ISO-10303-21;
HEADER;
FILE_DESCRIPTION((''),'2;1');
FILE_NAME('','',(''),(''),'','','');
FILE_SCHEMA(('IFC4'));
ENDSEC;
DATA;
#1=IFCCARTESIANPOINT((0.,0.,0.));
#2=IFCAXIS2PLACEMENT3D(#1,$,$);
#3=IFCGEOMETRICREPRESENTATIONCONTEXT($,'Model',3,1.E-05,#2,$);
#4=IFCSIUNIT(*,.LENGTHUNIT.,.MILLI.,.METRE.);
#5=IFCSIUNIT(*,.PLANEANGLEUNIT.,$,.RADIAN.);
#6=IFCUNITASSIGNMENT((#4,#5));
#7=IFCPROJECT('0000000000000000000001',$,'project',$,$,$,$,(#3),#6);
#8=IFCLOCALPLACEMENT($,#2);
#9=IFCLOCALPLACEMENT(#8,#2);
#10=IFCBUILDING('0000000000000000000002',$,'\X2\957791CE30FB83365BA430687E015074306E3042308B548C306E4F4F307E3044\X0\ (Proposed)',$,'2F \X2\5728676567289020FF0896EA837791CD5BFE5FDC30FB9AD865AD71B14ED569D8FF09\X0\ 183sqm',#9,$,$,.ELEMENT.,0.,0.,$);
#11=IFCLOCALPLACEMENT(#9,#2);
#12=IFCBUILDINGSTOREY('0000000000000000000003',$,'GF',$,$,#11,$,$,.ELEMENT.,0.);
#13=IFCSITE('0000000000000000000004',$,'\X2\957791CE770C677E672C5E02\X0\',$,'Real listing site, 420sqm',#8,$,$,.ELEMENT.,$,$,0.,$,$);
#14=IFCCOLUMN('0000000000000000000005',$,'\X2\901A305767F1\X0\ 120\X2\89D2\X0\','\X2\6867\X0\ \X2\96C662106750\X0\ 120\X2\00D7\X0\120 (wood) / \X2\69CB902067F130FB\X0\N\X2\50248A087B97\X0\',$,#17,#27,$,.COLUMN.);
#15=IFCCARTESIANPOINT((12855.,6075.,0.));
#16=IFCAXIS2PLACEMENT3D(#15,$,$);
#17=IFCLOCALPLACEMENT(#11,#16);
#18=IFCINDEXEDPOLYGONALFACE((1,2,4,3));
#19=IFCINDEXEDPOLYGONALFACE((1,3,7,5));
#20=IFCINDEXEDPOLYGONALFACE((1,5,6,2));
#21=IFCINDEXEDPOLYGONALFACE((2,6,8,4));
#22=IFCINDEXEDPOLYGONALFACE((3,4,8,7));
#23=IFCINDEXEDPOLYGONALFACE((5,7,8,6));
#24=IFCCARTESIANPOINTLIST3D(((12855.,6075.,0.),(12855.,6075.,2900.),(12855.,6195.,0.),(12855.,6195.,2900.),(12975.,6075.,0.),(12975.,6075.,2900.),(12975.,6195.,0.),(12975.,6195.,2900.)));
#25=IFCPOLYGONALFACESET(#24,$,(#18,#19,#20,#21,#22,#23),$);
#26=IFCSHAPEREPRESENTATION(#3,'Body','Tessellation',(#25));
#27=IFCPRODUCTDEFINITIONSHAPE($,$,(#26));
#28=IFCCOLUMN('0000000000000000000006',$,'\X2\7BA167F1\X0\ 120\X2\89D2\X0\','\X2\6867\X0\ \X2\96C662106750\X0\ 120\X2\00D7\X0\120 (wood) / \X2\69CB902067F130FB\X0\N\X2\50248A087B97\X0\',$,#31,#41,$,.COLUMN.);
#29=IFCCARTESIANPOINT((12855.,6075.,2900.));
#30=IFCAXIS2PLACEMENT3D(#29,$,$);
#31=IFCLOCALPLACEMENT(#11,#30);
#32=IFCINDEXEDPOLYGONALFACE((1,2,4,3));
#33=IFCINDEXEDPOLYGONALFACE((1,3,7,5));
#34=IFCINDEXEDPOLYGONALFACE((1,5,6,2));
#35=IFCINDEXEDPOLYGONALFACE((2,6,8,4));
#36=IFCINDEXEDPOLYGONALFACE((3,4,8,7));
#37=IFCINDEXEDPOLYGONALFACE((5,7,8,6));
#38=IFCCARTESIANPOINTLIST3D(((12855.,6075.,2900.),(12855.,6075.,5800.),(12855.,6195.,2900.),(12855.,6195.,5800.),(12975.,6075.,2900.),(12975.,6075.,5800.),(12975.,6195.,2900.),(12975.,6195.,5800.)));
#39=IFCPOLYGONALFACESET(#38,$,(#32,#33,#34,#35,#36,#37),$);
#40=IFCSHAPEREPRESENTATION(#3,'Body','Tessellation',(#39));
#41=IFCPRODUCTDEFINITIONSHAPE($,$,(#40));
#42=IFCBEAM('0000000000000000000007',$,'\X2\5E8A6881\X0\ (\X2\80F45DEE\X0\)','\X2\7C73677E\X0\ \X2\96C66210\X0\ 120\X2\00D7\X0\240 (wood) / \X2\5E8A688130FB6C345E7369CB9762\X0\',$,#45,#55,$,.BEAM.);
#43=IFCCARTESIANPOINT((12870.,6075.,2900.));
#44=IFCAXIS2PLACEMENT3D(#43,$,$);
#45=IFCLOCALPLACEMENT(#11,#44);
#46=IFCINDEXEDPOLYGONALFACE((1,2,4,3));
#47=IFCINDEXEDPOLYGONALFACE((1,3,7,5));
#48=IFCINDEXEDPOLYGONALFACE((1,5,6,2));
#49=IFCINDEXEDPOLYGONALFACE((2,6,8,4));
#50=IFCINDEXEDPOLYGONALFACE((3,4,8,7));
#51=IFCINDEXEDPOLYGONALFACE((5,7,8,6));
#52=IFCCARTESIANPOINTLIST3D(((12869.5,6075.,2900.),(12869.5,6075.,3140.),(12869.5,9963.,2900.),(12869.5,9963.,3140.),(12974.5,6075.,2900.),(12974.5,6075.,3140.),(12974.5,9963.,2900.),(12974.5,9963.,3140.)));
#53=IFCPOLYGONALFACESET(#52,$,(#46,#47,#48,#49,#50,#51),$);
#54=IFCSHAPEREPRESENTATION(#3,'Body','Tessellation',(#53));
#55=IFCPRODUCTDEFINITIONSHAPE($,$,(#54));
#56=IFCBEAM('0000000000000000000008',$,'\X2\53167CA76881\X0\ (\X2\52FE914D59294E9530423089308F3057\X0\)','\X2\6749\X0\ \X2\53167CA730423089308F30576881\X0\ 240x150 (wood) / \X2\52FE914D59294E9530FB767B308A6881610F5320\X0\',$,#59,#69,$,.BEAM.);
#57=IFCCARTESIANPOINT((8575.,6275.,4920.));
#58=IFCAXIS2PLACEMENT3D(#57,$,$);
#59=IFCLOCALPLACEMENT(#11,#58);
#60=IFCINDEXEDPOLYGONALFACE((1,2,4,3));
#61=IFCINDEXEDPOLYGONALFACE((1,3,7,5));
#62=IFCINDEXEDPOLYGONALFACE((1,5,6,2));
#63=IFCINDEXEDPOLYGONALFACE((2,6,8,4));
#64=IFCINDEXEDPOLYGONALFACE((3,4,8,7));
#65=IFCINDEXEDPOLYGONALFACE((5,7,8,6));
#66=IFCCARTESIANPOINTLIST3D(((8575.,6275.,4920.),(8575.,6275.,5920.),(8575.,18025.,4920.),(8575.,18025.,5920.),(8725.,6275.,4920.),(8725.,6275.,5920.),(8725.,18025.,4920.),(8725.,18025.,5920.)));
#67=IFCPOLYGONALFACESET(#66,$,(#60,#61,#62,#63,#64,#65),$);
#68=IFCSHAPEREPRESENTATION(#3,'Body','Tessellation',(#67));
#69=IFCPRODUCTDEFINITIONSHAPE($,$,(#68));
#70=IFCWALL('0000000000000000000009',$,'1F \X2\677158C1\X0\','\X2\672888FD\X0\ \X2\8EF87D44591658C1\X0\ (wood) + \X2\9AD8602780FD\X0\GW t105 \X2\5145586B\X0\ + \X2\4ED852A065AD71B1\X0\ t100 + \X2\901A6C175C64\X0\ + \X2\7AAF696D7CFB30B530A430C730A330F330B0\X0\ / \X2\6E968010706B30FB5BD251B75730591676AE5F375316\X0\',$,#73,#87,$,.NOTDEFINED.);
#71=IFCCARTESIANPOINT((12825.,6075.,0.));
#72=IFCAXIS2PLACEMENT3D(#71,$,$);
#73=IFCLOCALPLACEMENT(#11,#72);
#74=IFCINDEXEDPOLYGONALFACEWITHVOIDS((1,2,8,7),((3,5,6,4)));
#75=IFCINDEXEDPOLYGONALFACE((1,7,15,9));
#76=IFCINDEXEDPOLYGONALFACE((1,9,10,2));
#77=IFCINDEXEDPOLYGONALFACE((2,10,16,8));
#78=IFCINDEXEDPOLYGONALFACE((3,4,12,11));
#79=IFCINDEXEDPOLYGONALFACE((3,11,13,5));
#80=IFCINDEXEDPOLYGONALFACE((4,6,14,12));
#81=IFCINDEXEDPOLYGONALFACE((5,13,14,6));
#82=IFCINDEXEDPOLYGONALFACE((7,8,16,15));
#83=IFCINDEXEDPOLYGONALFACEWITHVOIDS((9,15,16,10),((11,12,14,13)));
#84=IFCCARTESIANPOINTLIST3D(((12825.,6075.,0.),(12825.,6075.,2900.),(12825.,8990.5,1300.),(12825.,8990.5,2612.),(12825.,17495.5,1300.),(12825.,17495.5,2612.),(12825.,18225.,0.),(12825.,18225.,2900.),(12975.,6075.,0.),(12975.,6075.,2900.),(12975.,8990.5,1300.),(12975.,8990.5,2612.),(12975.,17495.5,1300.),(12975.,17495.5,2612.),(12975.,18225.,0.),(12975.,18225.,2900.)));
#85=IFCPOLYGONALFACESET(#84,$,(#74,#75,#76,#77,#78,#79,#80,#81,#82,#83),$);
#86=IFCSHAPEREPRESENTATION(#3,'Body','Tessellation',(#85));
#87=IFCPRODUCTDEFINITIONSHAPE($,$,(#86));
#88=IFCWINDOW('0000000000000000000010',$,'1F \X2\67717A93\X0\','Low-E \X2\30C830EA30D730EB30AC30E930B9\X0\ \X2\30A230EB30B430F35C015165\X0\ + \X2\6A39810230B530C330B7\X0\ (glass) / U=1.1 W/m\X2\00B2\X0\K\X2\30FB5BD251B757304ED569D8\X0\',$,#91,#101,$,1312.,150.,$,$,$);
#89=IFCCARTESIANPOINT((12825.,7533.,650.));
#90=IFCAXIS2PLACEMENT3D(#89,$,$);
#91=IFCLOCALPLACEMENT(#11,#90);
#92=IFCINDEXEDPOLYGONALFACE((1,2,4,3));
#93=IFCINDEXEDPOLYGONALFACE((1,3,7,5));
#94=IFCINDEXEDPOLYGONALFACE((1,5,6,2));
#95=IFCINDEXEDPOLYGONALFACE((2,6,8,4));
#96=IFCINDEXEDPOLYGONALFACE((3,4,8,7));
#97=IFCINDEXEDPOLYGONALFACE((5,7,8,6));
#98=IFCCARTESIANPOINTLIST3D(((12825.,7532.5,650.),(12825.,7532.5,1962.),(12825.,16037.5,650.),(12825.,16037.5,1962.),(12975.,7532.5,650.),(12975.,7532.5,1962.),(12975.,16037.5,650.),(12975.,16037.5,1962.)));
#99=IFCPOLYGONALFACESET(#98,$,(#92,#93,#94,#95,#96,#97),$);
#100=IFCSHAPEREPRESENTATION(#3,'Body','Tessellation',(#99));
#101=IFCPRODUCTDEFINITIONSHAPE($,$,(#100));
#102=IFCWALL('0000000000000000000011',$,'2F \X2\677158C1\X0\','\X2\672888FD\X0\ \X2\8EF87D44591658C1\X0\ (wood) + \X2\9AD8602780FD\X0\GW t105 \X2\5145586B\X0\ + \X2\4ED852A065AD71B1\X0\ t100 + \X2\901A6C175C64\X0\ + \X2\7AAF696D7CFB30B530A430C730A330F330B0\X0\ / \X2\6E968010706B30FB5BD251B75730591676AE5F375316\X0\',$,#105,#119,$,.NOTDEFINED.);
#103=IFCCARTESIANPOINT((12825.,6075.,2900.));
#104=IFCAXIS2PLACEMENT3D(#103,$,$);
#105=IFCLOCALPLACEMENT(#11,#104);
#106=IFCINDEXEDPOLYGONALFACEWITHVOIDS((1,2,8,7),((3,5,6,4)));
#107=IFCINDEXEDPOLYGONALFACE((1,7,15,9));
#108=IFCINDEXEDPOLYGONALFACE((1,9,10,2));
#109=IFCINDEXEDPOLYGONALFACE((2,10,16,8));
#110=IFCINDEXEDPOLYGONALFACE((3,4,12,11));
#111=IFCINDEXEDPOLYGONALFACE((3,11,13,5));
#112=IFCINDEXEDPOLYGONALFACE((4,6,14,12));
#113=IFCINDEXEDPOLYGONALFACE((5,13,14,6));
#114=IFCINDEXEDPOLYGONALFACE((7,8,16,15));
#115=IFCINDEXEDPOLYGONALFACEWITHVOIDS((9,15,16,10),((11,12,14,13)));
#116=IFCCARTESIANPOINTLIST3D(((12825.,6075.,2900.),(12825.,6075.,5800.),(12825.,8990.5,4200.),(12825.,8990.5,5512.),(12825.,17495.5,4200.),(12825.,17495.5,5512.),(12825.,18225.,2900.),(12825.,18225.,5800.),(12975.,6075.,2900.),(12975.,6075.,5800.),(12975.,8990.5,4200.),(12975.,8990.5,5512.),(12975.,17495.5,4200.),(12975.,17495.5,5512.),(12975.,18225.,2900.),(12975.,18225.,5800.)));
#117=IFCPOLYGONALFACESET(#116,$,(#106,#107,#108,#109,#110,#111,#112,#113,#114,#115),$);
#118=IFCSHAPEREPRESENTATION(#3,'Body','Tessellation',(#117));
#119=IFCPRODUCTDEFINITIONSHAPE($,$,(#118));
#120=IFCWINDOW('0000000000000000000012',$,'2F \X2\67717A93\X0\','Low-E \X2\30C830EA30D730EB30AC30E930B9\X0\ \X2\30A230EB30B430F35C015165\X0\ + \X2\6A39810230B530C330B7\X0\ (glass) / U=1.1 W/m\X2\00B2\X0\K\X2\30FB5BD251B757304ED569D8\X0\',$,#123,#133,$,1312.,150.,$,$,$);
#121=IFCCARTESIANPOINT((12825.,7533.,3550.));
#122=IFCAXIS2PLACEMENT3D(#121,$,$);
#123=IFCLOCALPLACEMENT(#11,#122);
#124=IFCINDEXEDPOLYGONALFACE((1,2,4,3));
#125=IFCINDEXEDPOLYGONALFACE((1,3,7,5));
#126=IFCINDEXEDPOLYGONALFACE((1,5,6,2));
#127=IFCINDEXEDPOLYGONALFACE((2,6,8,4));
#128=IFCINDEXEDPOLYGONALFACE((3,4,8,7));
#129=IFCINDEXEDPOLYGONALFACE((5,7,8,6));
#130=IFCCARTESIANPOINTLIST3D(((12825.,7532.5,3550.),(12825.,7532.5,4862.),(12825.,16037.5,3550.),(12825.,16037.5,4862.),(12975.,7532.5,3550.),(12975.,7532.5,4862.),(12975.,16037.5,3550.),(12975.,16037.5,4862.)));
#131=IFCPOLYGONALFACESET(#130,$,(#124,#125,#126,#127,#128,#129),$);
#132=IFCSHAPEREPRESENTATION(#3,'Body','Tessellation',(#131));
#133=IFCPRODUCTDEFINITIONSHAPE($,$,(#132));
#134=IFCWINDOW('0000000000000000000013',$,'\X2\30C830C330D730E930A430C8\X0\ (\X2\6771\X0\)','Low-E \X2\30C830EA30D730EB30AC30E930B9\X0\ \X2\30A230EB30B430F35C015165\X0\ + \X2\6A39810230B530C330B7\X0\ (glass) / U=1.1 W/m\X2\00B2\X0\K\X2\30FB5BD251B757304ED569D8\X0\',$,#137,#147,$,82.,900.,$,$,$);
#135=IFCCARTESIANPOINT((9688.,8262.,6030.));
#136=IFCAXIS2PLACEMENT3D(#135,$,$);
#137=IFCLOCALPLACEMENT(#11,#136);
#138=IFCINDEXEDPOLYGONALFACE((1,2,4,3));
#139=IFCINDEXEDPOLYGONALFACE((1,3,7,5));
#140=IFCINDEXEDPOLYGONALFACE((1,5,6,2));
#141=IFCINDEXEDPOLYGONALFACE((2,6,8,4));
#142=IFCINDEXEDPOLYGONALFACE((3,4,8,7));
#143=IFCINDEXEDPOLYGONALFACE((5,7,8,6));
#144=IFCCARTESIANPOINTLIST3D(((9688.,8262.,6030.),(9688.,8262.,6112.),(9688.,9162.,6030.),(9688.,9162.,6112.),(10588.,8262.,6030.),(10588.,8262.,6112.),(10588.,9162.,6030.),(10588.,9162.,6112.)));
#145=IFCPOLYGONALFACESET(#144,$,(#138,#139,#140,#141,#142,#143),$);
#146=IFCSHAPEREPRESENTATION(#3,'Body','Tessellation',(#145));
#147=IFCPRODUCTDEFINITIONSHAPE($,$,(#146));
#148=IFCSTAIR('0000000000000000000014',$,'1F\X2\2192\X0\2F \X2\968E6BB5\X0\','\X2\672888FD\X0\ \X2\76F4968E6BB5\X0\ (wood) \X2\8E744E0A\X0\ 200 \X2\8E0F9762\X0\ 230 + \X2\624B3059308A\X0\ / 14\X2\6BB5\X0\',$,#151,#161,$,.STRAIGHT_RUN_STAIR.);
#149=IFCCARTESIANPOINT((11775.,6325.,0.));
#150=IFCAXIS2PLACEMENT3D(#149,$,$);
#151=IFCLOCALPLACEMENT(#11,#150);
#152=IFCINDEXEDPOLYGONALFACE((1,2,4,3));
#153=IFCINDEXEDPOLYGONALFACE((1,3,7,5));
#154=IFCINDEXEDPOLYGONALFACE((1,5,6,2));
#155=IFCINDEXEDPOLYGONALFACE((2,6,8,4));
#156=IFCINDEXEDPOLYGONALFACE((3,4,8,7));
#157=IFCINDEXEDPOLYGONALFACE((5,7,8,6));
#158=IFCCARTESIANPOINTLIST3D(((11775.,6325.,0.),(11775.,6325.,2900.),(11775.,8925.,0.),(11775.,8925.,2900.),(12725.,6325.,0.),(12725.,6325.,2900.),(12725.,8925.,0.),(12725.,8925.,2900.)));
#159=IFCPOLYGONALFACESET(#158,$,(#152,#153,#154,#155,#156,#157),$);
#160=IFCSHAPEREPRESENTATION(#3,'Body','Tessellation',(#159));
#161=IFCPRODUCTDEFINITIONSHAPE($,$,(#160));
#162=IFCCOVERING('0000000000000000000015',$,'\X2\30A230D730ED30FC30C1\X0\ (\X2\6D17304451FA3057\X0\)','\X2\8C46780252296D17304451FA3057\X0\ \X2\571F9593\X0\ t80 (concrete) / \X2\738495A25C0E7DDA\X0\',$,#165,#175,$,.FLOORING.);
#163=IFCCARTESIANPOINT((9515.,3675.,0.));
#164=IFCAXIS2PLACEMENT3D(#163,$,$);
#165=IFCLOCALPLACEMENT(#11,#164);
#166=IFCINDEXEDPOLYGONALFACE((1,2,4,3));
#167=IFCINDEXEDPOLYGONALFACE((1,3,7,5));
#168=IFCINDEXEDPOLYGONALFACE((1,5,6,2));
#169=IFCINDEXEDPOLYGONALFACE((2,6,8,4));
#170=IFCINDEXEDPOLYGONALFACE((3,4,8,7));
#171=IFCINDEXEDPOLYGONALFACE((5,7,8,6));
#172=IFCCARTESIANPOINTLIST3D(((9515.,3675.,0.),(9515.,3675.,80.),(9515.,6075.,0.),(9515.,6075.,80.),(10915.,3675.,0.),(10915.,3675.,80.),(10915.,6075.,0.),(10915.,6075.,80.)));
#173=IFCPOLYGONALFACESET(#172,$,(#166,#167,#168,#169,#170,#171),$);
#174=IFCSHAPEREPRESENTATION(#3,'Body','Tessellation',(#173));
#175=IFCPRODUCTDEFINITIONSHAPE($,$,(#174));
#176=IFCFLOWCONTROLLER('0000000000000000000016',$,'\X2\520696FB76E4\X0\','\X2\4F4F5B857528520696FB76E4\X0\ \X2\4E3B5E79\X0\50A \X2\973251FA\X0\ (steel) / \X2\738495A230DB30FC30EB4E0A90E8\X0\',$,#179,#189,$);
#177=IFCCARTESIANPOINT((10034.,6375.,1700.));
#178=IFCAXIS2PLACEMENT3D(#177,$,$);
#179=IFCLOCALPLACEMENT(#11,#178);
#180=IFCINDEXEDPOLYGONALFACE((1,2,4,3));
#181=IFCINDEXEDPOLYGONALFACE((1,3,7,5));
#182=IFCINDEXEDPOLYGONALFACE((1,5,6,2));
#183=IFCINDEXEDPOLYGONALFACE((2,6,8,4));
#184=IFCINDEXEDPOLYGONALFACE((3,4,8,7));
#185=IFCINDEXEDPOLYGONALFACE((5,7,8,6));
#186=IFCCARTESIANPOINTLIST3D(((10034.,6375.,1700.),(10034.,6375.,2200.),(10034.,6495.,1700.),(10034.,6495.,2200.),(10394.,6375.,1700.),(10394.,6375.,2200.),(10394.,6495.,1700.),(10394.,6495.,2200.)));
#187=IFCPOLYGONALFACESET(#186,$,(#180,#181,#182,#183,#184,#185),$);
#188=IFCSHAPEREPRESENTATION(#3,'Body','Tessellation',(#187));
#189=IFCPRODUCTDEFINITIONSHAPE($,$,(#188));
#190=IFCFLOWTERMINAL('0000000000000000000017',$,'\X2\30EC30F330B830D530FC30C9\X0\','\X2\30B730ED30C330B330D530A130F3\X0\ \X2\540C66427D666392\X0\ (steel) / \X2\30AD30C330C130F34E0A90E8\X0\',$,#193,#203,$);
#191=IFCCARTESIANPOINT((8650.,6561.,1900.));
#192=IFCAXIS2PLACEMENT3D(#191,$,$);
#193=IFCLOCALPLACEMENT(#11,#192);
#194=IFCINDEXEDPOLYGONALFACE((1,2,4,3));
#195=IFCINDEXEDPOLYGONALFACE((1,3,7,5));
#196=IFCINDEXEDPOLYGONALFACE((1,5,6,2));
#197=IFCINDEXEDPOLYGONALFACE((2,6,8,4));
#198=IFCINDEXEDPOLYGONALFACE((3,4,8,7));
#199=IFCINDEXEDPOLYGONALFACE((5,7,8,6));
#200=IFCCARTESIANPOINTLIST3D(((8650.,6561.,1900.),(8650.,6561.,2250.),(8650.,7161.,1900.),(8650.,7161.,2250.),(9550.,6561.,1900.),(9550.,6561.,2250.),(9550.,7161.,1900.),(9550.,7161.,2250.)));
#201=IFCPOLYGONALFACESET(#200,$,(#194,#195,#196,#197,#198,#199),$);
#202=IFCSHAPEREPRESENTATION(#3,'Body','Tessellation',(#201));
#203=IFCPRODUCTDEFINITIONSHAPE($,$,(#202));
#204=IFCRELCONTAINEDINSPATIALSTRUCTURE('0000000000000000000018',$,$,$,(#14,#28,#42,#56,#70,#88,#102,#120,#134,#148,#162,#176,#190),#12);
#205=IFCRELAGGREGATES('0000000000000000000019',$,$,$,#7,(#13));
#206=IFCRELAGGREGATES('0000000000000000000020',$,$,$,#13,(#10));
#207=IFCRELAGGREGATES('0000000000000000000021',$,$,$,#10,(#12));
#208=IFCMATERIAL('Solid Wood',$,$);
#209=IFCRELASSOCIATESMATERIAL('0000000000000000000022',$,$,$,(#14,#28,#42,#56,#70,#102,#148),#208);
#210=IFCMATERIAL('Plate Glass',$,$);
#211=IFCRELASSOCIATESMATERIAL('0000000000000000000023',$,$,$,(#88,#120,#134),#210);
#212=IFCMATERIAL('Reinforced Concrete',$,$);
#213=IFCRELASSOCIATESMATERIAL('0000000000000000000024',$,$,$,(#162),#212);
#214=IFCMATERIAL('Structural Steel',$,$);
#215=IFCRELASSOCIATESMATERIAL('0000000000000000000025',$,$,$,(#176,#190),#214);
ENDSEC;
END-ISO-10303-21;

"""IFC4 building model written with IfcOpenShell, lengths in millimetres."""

from ifc_helpers import new_model, si_unit, frame, frame_2d, origin, place, context, project, spatial, rectangle, extrude, material, element, fill, save


model = new_model("IFC4")

# Units and contexts
model_context = context("Model", 3, precision=1e-05, world=origin())
ifc_project = project(units=[si_unit("LENGTHUNIT", "METRE", prefix="MILLI"), si_unit("PLANEANGLEUNIT", "RADIAN")], contexts=[model_context])

# Site, building, storey
site_placement = place(None, origin())
site = spatial("IfcSite", under=ifc_project, at=site_placement, Name="長野県松本市", ObjectType="Real listing site, 420sqm", CompositionType="ELEMENT", RefElevation=0.0)
building_placement = place(site_placement, origin())
building = spatial("IfcBuilding", under=site, at=building_placement, Name="長野・茶室と縁側のある和の住まい (Proposed)", ObjectType="2F 在来木造（雪荷重対応・高断熱仕様） 183sqm", CompositionType="ELEMENT", ElevationOfRefHeight=0.0, ElevationOfTerrain=0.0)
storey_placement = place(building_placement, origin())
storey = spatial("IfcBuildingStorey", under=building, at=storey_placement, Name="GF", CompositionType="ELEMENT", Elevation=0.0)

# Columns
ifc_material_1 = material(Name="Solid Wood")
column_1_placement = place(storey_placement, frame((12855.0, 6075.0, 0.0)))
element("IfcColumn", 1, at=column_1_placement, inside=storey, material=ifc_material_1, Name="通し柱 120角", Description="桧 集成材 120×120 (wood) / 構造柱・N値計算", PredefinedType="COLUMN", context=model_context, shape_type="SweptSolid", body=[
    extrude(rectangle(XDim=120.0, YDim=120.0, at=frame_2d((60.0, 60.0))), frame((12855.0, 6075.0, 0.0)), (0.0, 0.0, 1.0), 2900.0),
])
column_2_placement = place(storey_placement, frame((12855.0, 6075.0, 2900.0)))
element("IfcColumn", 2, at=column_2_placement, inside=storey, material=ifc_material_1, Name="管柱 120角", Description="桧 集成材 120×120 (wood) / 構造柱・N値計算", PredefinedType="COLUMN", context=model_context, shape_type="SweptSolid", body=[
    extrude(rectangle(XDim=120.0, YDim=120.0, at=frame_2d((60.0, 60.0))), frame((12855.0, 6075.0, 2900.0)), (0.0, 0.0, 1.0), 2900.0),
])

# Beams
beam_1_placement = place(storey_placement, frame((12870.0, 6075.0, 2900.0)))
element("IfcBeam", 3, at=beam_1_placement, inside=storey, material=ifc_material_1, Name="床梁 (胴差)", Description="米松 集成 120×240 (wood) / 床梁・水平構面", PredefinedType="BEAM", context=model_context, shape_type="SweptSolid", body=[
    extrude(rectangle(XDim=105.0, YDim=3888.0, at=frame_2d((52.0, 1944.0))), frame((12870.0, 6075.0, 2900.0)), (0.0, 0.0, 1.0), 240.0),
])
beam_2_placement = place(storey_placement, frame((8575.0, 6275.0, 4920.0)))
element("IfcBeam", 4, at=beam_2_placement, inside=storey, material=ifc_material_1, Name="化粧梁 (勾配天井あらわし)", Description="杉 化粧あらわし梁 240x150 (wood) / 勾配天井・登り梁意匠", PredefinedType="BEAM", context=model_context, shape_type="SweptSolid", body=[
    extrude(rectangle(XDim=150.0, YDim=11750.0, at=frame_2d((75.0, 5875.0))), frame((8575.0, 6275.0, 4920.0)), (0.0, 0.0, 1.0), 1000.0),
])

# Wall, opening, window
wall_1_placement = place(storey_placement, frame((12825.0, 6075.0, 0.0)))
wall_1 = element("IfcWall", 5, at=wall_1_placement, inside=storey, material=ifc_material_1, Name="1F 東壁", Description="木製 軸組外壁 (wood) + 高性能GW t105 充填 + 付加断熱 t100 + 通気層 + 窯業系サイディング / 準耐火・寒冷地外皮強化", PredefinedType="NOTDEFINED", context=model_context, shape_type="SweptSolid", body=[
    extrude(rectangle(XDim=150.0, YDim=12150.0, at=frame_2d((75.0, 6075.0))), frame((12825.0, 6075.0, 0.0)), (0.0, 0.0, 1.0), 2900.0),
])
opening_1_placement = place(storey_placement, frame((12825.0, 7533.0, 650.0)))
opening_1 = element("IfcOpeningElement", 6, at=opening_1_placement, cuts=wall_1, PredefinedType="NOTDEFINED", context=model_context, shape_type="SweptSolid", body=[
    extrude(rectangle(XDim=150.0, YDim=8505.0, at=frame_2d((75.0, 4252.0))), frame((12825.0, 7533.0, 650.0)), (0.0, 0.0, 1.0), 1312.0),
])
ifc_material_2 = material(Name="Plate Glass")
window_1_placement = place(storey_placement, frame((12825.0, 7533.0, 650.0)))
window_1 = element("IfcWindow", 7, at=window_1_placement, inside=storey, material=ifc_material_2, Name="1F 東窓", Description="Low-E トリプルガラス アルゴン封入 + 樹脂サッシ (glass) / U=1.1 W/m²K・寒冷地仕様", OverallHeight=1312.0, OverallWidth=150.0, context=model_context, shape_type="SweptSolid", body=[
    extrude(rectangle(XDim=150.0, YDim=8505.0, at=frame_2d((75.0, 4252.0))), frame((12825.0, 7533.0, 650.0)), (0.0, 0.0, 1.0), 1312.0),
])
fill(opening_1, window_1)

# Wall, opening, window
wall_2_placement = place(storey_placement, frame((12825.0, 6075.0, 2900.0)))
wall_2 = element("IfcWall", 8, at=wall_2_placement, inside=storey, material=ifc_material_1, Name="2F 東壁", Description="木製 軸組外壁 (wood) + 高性能GW t105 充填 + 付加断熱 t100 + 通気層 + 窯業系サイディング / 準耐火・寒冷地外皮強化", PredefinedType="NOTDEFINED", context=model_context, shape_type="SweptSolid", body=[
    extrude(rectangle(XDim=150.0, YDim=12150.0, at=frame_2d((75.0, 6075.0))), frame((12825.0, 6075.0, 2900.0)), (0.0, 0.0, 1.0), 2900.0),
])
opening_2_placement = place(storey_placement, frame((12825.0, 7533.0, 3550.0)))
opening_2 = element("IfcOpeningElement", 9, at=opening_2_placement, cuts=wall_2, PredefinedType="NOTDEFINED", context=model_context, shape_type="SweptSolid", body=[
    extrude(rectangle(XDim=150.0, YDim=8505.0, at=frame_2d((75.0, 4252.0))), frame((12825.0, 7533.0, 3550.0)), (0.0, 0.0, 1.0), 1312.0),
])
window_2_placement = place(storey_placement, frame((12825.0, 7533.0, 3550.0)))
window_2 = element("IfcWindow", 10, at=window_2_placement, inside=storey, material=ifc_material_2, Name="2F 東窓", Description="Low-E トリプルガラス アルゴン封入 + 樹脂サッシ (glass) / U=1.1 W/m²K・寒冷地仕様", OverallHeight=1312.0, OverallWidth=150.0, context=model_context, shape_type="SweptSolid", body=[
    extrude(rectangle(XDim=150.0, YDim=8505.0, at=frame_2d((75.0, 4252.0))), frame((12825.0, 7533.0, 3550.0)), (0.0, 0.0, 1.0), 1312.0),
])
fill(opening_2, window_2)

# Window
window_3_placement = place(storey_placement, frame((9688.0, 8262.0, 6030.0)))
element("IfcWindow", 11, at=window_3_placement, inside=storey, material=ifc_material_2, Name="トップライト (東)", Description="Low-E トリプルガラス アルゴン封入 + 樹脂サッシ (glass) / U=1.1 W/m²K・寒冷地仕様", OverallHeight=82.0, OverallWidth=900.0, context=model_context, shape_type="SweptSolid", body=[
    extrude(rectangle(XDim=900.0, YDim=900.0, at=frame_2d((450.0, 450.0))), frame((9688.0, 8262.0, 6030.0)), (0.0, 0.0, 1.0), 82.0),
])

# Stair
stair_placement = place(storey_placement, frame((11775.0, 6325.0, 0.0)))
element("IfcStair", 12, at=stair_placement, inside=storey, material=ifc_material_1, Name="1F→2F 階段", Description="木製 直階段 (wood) 蹴上 200 踏面 230 + 手すり / 14段", PredefinedType="STRAIGHT_RUN_STAIR", context=model_context, shape_type="SweptSolid", body=[
    extrude(rectangle(XDim=950.0, YDim=2600.0, at=frame_2d((475.0, 1300.0))), frame((11775.0, 6325.0, 0.0)), (0.0, 0.0, 1.0), 2900.0),
])

# Covering
ifc_material_3 = material(Name="Reinforced Concrete")
covering_placement = place(storey_placement, frame((9515.0, 3675.0, 0.0)))
element("IfcCovering", 13, at=covering_placement, inside=storey, material=ifc_material_3, Name="アプローチ (洗い出し)", Description="豆砂利洗い出し 土間 t80 (concrete) / 玄関導線", PredefinedType="FLOORING", context=model_context, shape_type="SweptSolid", body=[
    extrude(rectangle(XDim=1400.0, YDim=2400.0, at=frame_2d((700.0, 1200.0))), frame((9515.0, 3675.0, 0.0)), (0.0, 0.0, 1.0), 80.0),
])

# Flow controller
ifc_material_4 = material(Name="Structural Steel")
flow_controller_placement = place(storey_placement, frame((10034.0, 6375.0, 1700.0)))
element("IfcFlowController", 14, at=flow_controller_placement, inside=storey, material=ifc_material_4, Name="分電盤", Description="住宅用分電盤 主幹50A 露出 (steel) / 玄関ホール上部", context=model_context, shape_type="SweptSolid", body=[
    extrude(rectangle(XDim=360.0, YDim=120.0, at=frame_2d((180.0, 60.0))), frame((10034.0, 6375.0, 1700.0)), (0.0, 0.0, 1.0), 500.0),
])

# Flow terminal
flow_terminal_1_placement = place(storey_placement, frame((8650.0, 6561.0, 1900.0)))
element("IfcFlowTerminal", 15, at=flow_terminal_1_placement, inside=storey, material=ifc_material_4, Name="レンジフード", Description="シロッコファン 同時給排 (steel) / キッチン上部", context=model_context, shape_type="SweptSolid", body=[
    extrude(rectangle(XDim=900.0, YDim=600.0, at=frame_2d((450.0, 300.0))), frame((8650.0, 6561.0, 1900.0)), (0.0, 0.0, 1.0), 350.0),
])

save(model, "model.ifc")
